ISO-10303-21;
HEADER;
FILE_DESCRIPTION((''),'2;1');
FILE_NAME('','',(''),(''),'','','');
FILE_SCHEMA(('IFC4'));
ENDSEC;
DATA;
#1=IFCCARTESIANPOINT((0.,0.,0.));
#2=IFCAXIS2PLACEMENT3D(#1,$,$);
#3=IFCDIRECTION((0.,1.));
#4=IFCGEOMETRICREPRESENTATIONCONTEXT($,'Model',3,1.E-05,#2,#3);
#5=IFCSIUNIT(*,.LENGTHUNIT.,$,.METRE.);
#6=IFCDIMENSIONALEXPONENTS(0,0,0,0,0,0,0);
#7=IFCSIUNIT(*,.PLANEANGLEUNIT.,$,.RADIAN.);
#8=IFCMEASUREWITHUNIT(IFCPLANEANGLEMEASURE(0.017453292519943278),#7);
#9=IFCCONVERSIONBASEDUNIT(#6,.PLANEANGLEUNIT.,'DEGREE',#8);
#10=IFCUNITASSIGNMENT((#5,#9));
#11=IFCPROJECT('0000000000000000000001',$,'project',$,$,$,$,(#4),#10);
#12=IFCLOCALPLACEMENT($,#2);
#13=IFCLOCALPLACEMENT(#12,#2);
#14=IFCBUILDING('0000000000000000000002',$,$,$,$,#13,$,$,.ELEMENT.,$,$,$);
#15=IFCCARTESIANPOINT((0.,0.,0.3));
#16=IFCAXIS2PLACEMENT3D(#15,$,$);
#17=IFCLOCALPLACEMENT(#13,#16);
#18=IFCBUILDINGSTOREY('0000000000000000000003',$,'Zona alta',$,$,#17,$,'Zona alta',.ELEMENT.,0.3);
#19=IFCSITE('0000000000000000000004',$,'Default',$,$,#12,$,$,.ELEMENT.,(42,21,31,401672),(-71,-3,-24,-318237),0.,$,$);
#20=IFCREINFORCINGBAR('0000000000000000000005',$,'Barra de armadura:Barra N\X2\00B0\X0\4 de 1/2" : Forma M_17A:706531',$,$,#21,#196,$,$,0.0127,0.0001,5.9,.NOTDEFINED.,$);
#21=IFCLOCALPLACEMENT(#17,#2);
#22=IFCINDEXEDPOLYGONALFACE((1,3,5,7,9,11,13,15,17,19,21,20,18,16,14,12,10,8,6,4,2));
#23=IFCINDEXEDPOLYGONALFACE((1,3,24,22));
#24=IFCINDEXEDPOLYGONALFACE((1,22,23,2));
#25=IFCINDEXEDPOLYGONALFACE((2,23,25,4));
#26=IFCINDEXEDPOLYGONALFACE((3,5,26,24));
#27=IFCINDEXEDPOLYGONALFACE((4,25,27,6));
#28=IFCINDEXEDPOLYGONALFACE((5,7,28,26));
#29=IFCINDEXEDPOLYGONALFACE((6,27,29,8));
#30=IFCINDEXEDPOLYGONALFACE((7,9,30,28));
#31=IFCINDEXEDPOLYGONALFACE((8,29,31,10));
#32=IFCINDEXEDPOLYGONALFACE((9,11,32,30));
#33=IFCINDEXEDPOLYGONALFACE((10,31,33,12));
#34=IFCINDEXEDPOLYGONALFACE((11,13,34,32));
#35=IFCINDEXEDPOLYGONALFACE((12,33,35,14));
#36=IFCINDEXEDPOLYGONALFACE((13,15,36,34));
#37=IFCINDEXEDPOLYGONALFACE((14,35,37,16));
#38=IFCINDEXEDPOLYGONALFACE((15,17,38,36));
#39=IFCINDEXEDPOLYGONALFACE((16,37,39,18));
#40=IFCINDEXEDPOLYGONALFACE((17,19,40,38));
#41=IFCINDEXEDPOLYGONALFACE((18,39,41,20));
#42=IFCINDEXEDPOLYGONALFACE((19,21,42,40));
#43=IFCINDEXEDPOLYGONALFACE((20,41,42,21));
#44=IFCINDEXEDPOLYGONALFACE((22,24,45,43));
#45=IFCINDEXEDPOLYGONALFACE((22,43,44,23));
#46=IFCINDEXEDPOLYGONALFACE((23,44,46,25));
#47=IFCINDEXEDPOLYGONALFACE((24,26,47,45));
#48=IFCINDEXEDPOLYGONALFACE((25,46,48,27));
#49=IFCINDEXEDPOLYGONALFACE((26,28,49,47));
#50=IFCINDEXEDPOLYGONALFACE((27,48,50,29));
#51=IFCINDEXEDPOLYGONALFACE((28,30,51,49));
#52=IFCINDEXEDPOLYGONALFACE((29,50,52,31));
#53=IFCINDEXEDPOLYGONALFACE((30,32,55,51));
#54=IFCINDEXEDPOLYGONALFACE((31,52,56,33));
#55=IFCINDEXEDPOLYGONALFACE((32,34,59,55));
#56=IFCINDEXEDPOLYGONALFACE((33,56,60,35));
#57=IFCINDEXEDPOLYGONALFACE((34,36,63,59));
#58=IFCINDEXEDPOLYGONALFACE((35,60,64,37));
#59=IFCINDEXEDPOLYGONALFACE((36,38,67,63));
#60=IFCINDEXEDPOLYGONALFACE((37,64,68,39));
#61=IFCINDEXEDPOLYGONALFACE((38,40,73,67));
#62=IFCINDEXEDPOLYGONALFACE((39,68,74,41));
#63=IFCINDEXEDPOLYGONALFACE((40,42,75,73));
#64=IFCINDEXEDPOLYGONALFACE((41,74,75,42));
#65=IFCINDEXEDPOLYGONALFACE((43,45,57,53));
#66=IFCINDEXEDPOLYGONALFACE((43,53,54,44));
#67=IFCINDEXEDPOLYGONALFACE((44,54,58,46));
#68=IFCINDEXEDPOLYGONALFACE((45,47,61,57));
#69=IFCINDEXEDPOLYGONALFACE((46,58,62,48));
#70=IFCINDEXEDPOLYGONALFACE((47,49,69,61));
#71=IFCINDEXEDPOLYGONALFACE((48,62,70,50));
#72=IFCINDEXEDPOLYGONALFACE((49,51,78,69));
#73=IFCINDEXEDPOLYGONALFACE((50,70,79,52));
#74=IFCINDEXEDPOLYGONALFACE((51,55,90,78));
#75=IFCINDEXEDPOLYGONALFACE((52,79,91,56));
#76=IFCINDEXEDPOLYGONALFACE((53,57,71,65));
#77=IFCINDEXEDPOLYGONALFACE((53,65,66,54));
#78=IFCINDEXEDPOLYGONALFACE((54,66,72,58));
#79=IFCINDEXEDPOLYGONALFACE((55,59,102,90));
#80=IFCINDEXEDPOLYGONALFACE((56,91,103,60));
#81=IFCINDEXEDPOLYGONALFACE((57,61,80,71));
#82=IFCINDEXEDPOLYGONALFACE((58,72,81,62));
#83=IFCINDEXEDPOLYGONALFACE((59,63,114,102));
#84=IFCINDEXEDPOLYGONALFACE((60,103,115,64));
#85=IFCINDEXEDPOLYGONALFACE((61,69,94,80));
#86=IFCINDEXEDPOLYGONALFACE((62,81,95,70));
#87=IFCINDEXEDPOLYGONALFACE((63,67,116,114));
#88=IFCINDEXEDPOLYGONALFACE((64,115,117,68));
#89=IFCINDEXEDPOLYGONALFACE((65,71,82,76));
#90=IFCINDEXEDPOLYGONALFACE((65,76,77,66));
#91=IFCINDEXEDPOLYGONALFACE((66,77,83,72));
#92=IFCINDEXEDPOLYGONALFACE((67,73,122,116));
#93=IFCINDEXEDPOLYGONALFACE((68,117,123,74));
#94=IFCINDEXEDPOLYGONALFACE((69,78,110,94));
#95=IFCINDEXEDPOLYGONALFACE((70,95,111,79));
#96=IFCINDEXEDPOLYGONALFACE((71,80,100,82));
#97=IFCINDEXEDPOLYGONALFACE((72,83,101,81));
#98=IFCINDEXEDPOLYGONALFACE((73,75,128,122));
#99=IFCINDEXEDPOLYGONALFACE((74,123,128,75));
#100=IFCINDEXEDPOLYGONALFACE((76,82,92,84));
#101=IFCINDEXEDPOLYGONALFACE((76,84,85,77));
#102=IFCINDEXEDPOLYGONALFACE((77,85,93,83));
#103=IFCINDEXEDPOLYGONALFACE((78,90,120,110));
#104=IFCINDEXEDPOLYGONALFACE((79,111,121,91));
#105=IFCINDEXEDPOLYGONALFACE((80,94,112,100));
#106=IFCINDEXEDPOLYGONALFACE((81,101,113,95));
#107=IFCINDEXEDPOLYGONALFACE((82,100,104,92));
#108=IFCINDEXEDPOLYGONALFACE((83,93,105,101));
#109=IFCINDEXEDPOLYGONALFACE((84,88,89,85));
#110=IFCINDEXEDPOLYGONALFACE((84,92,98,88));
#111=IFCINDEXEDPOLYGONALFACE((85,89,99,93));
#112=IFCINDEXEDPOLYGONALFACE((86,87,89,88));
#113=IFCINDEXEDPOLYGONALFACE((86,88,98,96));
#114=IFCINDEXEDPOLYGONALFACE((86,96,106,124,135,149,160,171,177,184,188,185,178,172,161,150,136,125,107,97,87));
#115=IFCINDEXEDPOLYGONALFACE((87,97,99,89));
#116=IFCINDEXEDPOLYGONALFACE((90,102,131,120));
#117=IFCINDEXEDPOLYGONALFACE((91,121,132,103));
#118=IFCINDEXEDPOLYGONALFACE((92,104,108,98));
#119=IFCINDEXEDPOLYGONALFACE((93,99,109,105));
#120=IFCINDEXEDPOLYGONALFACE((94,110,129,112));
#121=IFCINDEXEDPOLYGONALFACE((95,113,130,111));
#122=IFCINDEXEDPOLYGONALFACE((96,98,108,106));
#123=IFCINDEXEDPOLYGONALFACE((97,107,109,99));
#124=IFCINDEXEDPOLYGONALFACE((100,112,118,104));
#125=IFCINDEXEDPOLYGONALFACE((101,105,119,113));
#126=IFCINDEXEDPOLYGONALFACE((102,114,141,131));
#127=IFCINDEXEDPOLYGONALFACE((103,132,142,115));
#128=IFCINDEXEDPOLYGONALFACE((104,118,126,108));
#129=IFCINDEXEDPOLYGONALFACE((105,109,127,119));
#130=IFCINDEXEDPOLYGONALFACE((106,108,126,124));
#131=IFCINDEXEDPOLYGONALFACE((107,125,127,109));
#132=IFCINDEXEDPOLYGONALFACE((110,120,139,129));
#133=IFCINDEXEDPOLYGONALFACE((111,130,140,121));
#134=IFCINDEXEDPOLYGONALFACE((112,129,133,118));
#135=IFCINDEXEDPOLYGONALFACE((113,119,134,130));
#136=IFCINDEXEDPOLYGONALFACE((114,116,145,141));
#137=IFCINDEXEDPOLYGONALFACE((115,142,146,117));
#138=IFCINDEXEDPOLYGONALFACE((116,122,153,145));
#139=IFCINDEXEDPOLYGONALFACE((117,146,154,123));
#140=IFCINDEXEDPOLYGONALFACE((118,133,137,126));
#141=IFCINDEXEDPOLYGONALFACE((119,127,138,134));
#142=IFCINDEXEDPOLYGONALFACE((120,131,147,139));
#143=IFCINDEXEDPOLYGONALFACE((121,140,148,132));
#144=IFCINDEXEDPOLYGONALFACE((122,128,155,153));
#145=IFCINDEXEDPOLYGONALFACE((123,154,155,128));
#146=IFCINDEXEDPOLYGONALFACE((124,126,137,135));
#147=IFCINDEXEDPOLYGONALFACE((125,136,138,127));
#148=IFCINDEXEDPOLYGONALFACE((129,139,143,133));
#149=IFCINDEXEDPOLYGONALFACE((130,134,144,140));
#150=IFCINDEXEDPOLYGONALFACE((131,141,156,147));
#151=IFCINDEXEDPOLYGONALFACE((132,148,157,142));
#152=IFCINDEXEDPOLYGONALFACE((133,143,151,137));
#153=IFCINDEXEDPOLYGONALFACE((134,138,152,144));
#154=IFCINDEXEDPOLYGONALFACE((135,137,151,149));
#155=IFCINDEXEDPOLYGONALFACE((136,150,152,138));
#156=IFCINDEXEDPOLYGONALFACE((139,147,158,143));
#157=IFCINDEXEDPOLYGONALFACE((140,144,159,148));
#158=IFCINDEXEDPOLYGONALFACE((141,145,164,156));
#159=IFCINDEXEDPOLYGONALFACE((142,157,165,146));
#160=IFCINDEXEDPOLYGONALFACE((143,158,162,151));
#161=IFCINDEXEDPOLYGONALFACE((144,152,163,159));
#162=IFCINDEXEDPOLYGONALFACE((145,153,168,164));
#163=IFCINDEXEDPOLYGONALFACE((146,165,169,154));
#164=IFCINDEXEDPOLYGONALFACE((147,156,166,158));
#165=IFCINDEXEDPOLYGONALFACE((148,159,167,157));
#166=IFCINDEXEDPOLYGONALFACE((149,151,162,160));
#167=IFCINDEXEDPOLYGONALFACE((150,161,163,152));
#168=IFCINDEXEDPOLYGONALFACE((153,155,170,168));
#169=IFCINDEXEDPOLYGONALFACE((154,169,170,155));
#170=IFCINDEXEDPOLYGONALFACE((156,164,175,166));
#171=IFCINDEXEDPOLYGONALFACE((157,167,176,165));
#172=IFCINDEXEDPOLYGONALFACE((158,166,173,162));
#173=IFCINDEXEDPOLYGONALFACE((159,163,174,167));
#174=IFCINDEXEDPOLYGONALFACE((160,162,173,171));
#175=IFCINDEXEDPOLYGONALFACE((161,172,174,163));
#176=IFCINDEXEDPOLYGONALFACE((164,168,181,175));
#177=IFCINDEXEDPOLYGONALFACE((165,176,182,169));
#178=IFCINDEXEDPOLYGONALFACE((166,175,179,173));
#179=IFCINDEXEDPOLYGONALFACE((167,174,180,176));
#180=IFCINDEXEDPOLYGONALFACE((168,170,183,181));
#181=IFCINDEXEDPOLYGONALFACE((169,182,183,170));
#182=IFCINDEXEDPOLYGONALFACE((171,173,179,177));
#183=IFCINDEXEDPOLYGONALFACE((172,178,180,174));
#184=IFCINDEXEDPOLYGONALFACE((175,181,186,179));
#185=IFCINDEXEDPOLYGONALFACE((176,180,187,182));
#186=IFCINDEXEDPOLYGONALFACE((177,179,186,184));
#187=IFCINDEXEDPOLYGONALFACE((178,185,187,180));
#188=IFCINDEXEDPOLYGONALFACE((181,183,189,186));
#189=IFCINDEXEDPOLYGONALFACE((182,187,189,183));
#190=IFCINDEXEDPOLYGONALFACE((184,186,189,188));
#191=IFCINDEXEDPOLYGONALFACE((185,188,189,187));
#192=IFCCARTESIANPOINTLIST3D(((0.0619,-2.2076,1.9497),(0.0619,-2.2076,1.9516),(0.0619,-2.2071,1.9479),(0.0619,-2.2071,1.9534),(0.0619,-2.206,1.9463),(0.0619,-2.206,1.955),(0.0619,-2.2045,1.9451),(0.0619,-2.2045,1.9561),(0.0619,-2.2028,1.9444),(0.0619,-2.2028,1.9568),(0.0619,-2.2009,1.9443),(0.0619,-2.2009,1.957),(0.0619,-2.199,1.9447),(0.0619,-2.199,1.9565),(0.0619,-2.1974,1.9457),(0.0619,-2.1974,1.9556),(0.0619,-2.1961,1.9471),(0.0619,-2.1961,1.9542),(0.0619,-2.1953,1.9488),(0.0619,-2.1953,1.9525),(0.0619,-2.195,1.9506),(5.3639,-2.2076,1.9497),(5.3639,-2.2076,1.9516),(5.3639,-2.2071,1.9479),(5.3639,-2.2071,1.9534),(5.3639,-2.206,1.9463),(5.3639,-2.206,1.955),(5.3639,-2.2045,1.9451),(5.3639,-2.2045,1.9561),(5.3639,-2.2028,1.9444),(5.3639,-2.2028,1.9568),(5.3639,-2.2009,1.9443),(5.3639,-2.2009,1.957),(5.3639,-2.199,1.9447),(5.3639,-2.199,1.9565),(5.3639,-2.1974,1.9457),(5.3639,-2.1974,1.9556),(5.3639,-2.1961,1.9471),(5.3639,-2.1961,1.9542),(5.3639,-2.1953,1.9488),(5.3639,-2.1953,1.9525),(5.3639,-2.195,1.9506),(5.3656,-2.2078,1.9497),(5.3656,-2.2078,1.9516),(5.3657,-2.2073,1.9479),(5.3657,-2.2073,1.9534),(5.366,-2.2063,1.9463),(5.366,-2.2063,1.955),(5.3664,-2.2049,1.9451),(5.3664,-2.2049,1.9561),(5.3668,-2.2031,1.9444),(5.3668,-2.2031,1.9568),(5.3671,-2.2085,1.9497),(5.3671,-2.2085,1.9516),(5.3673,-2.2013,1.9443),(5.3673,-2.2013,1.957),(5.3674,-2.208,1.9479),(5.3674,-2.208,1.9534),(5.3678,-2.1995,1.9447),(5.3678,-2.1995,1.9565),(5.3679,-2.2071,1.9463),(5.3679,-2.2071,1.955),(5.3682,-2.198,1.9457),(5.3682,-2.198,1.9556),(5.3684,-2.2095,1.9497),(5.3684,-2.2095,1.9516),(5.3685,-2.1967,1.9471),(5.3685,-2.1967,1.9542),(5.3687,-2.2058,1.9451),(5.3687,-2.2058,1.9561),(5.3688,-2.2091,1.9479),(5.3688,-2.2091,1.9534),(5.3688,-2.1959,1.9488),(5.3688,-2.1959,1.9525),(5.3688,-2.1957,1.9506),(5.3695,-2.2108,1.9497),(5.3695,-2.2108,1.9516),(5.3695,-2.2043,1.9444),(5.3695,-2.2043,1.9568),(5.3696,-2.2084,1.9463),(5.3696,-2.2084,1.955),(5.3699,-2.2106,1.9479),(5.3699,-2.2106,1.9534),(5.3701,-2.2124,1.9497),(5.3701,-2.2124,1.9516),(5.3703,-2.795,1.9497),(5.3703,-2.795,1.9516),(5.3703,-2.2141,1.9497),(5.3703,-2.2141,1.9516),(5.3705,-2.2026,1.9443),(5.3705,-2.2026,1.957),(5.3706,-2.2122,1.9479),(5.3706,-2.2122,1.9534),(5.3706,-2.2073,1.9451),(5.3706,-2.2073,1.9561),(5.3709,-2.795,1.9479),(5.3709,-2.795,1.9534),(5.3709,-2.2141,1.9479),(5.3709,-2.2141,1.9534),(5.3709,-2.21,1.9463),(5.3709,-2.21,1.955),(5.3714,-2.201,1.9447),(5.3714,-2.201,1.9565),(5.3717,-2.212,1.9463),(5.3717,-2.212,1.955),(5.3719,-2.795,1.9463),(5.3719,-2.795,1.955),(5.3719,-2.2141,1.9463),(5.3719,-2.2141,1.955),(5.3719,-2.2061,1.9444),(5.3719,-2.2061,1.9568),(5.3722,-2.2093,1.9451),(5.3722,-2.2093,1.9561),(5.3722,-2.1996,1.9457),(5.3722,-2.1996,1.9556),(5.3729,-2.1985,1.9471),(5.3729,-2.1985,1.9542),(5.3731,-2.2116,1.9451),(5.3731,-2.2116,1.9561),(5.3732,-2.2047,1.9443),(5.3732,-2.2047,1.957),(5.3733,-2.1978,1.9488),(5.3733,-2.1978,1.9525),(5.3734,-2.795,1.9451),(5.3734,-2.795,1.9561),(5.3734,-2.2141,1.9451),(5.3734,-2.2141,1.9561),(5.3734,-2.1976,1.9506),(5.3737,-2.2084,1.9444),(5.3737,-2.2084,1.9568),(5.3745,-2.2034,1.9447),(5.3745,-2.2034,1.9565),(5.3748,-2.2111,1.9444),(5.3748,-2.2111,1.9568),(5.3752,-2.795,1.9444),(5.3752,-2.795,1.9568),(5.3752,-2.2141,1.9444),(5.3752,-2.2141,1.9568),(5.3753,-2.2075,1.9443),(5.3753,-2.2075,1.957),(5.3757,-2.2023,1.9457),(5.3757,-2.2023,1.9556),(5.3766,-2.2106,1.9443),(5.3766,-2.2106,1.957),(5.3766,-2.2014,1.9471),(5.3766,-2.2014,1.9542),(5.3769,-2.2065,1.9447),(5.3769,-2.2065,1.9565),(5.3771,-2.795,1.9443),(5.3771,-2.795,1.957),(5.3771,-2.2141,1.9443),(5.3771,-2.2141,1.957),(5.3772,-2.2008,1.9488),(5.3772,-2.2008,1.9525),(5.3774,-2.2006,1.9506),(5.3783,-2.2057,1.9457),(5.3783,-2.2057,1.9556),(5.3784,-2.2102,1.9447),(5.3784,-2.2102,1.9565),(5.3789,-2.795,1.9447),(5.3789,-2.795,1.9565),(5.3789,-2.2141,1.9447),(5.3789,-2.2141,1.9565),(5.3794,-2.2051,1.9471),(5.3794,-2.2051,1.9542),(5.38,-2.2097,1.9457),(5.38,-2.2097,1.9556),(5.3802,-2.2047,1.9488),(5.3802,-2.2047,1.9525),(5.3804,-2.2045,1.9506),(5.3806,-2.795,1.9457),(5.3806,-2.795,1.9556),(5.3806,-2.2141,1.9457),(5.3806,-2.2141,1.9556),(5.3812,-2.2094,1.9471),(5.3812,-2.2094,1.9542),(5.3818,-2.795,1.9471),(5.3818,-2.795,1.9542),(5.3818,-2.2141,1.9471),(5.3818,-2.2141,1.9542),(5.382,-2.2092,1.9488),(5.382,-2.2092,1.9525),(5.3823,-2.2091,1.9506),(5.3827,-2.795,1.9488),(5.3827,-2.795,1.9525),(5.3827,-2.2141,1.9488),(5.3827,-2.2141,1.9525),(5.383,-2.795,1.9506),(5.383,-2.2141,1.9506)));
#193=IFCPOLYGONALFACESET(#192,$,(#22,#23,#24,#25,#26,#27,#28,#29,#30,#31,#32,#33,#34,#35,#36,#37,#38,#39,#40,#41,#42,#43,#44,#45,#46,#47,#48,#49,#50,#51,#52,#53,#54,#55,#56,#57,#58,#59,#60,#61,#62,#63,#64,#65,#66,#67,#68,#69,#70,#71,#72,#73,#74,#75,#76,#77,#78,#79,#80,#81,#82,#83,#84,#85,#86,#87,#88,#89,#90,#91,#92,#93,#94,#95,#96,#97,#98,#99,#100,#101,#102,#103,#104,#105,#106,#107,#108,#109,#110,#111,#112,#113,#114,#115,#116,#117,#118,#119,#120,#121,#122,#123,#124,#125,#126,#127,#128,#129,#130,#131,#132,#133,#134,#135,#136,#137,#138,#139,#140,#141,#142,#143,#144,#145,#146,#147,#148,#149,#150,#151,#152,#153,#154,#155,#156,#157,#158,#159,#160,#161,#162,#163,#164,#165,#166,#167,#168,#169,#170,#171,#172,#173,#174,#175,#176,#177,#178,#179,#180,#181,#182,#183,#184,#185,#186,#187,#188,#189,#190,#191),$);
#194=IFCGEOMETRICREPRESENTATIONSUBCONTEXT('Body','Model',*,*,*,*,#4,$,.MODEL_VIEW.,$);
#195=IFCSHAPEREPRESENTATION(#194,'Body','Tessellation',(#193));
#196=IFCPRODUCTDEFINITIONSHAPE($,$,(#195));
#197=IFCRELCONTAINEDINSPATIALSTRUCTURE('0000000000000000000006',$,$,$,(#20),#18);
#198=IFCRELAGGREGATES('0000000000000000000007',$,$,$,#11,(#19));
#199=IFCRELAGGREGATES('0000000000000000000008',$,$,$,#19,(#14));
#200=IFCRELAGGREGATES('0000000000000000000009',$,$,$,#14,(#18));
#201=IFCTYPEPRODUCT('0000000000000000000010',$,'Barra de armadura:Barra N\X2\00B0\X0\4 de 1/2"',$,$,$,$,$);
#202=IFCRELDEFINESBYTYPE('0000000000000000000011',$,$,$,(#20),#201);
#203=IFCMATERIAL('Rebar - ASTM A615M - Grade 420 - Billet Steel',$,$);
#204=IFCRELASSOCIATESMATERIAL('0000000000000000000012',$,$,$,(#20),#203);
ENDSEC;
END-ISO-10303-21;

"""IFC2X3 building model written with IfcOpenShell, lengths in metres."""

from ifc_helpers import new_model, entity, si_unit, converted_unit, direction, frame, origin, place, context, subcontext, project, spatial, material, type_object, element, save


model = new_model("IFC2X3")

# Units and contexts
model_context = context("Model", 3, precision=1e-05, world=origin(), true_north=direction((0.0, 1.0)))
body_context = subcontext(model_context, "Body", "Model", "MODEL_VIEW")
ifc_project = project(units=[si_unit("LENGTHUNIT", "METRE"), converted_unit("PLANEANGLEUNIT", "DEGREE", entity("IfcPlaneAngleMeasure", 0.017453292519943278), si_unit("PLANEANGLEUNIT", "RADIAN"), dimensions=[0, 0, 0, 0, 0, 0, 0])], contexts=[model_context])

# Site, building, storey
site_placement = place(None, origin())
site = spatial("IfcSite", under=ifc_project, at=site_placement, Name="Default", CompositionType="ELEMENT", RefLatitude=(42, 21, 31, 401672), RefLongitude=(-71, -3, -24, -318237), RefElevation=0.0)
building_placement = place(site_placement, origin())
building = spatial("IfcBuilding", under=site, at=building_placement, CompositionType="ELEMENT")
storey_placement = place(building_placement, frame((0.0, 0.0, 0.3)))
storey = spatial("IfcBuildingStorey", under=building, at=storey_placement, Name="Zona alta", LongName="Zona alta", CompositionType="ELEMENT", Elevation=0.3)

# Reinforcing bar
ifc_material = material(Name="Rebar - ASTM A615M - Grade 420 - Billet Steel")
type_product_1 = type_object("IfcTypeProduct", Name="Barra de armadura:Barra N°4 de 1/2\"")
reinforcing_bar_1_placement = place(storey_placement, origin())
element("IfcReinforcingBar", 1, at=reinforcing_bar_1_placement, inside=storey, type_object=type_product_1, material=ifc_material, Name="Barra de armadura:Barra N°4 de 1/2\" : Forma M_17A:706531", BarLength=5.9, BarRole="NOTDEFINED", CrossSectionArea=0.0001, NominalDiameter=0.0127, context=body_context, shape_type="AdvancedSweptSolid", body=[
    entity("IfcSweptDiskSolid", entity("IfcCompositeCurve", [entity("IfcCompositeCurveSegment", "CONTINUOUS", True, entity("IfcPolyline", [entity("IfcCartesianPoint", [0.0619, -2.2014, 1.9506]), entity("IfcCartesianPoint", [5.3639, -2.2014, 1.9506])])), entity("IfcCompositeCurveSegment", "CONTINUOUS", True, entity("IfcTrimmedCurve", entity("IfcCircle", entity("IfcAxis2Placement3D", entity("IfcCartesianPoint", [5.3639, -2.2141, 1.9506]), entity("IfcDirection", [0.0, 0.0, -1.0]), entity("IfcDirection", [1.0, 0.0, 0.0])), 0.0127), [entity("IfcParameterValue", 270.0)], [entity("IfcParameterValue", 360.0)], True, "PARAMETER")), entity("IfcCompositeCurveSegment", "CONTINUOUS", True, entity("IfcPolyline", [entity("IfcCartesianPoint", [5.3766, -2.2141, 1.9506]), entity("IfcCartesianPoint", [5.3766, -2.795, 1.9506])]))], False), 0.0063, None, 0.0, 92.0),
])

save(model, "model.ifc")
